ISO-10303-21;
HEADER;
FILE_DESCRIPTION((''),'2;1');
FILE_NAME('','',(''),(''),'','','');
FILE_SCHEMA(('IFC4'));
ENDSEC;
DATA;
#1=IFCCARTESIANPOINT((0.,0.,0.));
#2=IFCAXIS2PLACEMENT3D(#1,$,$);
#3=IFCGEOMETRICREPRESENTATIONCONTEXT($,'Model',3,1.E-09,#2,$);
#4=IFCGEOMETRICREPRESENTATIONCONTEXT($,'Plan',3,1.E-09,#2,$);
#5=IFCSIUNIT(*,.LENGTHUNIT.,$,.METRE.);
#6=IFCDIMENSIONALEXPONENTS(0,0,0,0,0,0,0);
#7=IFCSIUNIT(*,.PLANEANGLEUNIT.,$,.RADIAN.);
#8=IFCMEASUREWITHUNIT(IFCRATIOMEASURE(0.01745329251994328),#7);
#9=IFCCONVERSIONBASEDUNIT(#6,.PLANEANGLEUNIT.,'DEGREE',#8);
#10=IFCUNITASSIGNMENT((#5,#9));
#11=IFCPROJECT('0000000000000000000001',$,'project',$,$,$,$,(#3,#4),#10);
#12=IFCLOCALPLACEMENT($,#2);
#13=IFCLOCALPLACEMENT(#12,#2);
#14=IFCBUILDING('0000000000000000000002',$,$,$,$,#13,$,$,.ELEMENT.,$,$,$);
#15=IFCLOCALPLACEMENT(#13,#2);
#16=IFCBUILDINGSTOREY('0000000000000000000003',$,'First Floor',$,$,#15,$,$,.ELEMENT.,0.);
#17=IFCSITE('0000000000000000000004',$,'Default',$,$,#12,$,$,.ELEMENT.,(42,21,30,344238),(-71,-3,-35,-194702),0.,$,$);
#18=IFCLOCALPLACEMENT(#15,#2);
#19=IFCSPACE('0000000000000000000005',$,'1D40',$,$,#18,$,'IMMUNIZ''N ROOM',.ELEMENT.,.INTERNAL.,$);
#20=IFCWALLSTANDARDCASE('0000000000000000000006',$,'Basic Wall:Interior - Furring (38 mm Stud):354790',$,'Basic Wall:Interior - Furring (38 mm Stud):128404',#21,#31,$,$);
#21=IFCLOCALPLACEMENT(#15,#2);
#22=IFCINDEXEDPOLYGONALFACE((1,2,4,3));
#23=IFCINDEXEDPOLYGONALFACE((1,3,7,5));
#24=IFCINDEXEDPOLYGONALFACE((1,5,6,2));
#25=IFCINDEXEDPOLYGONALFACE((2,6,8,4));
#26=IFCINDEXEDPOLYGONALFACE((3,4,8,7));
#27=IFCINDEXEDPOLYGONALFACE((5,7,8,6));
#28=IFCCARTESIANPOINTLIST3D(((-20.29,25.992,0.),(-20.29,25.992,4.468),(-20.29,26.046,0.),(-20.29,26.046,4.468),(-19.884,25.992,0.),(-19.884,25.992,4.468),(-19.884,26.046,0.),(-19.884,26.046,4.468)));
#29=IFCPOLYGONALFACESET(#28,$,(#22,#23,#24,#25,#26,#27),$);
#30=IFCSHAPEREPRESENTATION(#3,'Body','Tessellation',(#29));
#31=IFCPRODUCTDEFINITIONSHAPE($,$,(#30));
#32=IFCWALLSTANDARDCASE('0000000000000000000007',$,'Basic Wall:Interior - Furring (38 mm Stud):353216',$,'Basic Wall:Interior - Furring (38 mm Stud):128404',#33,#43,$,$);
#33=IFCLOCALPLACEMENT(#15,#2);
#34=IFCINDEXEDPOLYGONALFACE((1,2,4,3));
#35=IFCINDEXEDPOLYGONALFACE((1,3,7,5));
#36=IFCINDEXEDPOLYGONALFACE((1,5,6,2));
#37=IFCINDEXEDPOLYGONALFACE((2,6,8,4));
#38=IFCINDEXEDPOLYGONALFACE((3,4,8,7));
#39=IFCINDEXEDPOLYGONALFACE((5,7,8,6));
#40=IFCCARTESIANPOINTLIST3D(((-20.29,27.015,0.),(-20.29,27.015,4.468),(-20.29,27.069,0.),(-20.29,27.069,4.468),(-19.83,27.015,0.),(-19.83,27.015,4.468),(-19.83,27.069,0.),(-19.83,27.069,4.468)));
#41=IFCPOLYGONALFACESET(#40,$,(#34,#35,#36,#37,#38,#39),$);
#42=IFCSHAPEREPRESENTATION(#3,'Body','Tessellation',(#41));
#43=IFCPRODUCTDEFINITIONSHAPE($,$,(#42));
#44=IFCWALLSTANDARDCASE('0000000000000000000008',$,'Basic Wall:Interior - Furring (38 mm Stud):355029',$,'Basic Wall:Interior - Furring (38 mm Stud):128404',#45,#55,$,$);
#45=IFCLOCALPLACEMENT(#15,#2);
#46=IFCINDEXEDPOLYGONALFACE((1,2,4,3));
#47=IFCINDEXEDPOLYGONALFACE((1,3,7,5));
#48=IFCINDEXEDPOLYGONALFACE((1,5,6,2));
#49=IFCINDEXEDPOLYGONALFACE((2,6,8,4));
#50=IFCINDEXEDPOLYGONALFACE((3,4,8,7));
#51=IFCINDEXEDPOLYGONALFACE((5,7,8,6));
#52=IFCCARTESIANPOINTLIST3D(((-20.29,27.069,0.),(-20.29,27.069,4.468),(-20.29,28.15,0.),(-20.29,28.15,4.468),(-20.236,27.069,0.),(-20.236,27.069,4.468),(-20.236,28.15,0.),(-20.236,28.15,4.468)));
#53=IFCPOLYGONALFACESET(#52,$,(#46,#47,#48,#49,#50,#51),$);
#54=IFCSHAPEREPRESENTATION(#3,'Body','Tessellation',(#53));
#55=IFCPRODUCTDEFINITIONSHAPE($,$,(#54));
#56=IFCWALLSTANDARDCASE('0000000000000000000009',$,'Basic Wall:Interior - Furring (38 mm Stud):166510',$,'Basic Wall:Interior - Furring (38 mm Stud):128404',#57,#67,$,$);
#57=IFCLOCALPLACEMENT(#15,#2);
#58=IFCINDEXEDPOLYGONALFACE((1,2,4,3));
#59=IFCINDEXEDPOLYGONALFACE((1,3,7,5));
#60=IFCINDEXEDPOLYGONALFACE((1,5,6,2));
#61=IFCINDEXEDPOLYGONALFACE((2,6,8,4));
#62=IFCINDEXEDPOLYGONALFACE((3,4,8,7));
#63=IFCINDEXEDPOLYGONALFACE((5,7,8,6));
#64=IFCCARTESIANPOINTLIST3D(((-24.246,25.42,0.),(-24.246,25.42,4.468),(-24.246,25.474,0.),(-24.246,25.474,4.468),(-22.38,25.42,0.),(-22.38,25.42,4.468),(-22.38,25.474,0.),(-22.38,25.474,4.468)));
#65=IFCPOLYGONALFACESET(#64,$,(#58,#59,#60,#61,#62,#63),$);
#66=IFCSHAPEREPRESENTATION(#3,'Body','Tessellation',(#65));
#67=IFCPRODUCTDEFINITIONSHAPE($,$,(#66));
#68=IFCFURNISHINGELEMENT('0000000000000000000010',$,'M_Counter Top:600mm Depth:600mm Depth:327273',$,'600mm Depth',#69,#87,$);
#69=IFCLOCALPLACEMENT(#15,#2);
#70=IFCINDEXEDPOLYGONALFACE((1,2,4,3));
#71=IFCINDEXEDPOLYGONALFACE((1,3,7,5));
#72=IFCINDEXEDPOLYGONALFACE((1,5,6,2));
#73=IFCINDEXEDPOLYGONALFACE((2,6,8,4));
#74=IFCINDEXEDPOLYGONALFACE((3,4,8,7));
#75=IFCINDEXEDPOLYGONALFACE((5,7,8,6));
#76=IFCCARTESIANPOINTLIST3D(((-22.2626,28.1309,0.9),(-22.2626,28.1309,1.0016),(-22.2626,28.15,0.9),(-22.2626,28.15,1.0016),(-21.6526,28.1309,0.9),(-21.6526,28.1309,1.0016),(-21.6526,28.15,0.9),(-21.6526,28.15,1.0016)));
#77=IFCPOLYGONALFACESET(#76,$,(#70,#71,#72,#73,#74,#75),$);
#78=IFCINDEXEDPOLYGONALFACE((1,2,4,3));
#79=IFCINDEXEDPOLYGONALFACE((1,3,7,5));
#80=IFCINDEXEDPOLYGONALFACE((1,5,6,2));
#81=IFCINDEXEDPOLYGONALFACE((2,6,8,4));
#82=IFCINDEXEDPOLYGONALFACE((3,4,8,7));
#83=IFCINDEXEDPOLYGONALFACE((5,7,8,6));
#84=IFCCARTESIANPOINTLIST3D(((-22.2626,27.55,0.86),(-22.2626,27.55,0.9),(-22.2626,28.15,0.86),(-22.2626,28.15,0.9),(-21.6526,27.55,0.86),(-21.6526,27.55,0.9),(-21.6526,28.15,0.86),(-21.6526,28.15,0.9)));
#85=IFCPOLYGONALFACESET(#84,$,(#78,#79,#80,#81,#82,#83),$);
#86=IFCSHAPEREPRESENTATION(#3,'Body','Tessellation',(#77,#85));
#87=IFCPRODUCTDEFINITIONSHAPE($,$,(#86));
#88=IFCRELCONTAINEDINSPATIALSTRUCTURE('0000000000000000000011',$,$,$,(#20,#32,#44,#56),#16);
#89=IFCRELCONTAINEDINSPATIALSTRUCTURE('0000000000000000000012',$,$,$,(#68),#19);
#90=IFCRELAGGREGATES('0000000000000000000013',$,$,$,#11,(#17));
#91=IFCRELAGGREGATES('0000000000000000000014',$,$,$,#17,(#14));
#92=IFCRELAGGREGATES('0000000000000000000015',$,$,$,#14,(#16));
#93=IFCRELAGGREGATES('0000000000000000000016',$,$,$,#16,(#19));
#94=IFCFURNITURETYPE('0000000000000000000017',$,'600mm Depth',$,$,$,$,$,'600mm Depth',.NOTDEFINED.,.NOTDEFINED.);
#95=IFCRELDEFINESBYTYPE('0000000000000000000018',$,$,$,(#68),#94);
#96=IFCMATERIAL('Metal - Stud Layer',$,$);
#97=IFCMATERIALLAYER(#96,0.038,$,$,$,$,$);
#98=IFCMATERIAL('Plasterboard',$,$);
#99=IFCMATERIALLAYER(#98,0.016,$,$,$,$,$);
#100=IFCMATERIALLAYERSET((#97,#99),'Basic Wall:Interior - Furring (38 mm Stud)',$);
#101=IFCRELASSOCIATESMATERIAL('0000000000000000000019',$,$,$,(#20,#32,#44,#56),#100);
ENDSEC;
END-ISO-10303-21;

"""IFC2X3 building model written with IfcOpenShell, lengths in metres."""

from ifc_helpers import new_model, entity, si_unit, converted_unit, frame, frame_2d, origin, origin_2d_with_axis, place, context, project, spatial, rectangle, extrude, source, transform, mapped, material, layer, layer_set, layer_usage, type_object, type_shapes, element, save


model = new_model("IFC2X3")

# Units and contexts
model_context = context("Model", 3, precision=1e-09, world=origin())
plan_context = context("Plan", 3, precision=1e-09, world=origin())
ifc_project = project(units=[si_unit("LENGTHUNIT", "METRE"), converted_unit("PLANEANGLEUNIT", "DEGREE", entity("IfcRatioMeasure", 0.01745329251994328), si_unit("PLANEANGLEUNIT", "RADIAN"), dimensions=[0, 0, 0, 0, 0, 0, 0])], contexts=[model_context, plan_context])

# Site, building, storey
site_placement = place(None, origin())
site = spatial("IfcSite", under=ifc_project, at=site_placement, Name="Default", CompositionType="ELEMENT", RefLatitude=(42, 21, 30, 344238), RefLongitude=(-71, -3, -35, -194702), RefElevation=0.0)
building_placement = place(site_placement, origin())
building = spatial("IfcBuilding", under=site, at=building_placement, CompositionType="ELEMENT")
storey_placement = place(building_placement, origin())
storey = spatial("IfcBuildingStorey", under=building, at=storey_placement, Name="First Floor", CompositionType="ELEMENT", Elevation=0.0)

# Shared definitions
ifc_material_1 = material(Name="Metal - Stud Layer")
ifc_material_2 = material(Name="Plasterboard")

# Shared definitions
ifc_layer_1 = layer(ifc_material_1, 0.038)
ifc_layer_2 = layer(ifc_material_2, 0.016)
ifc_layer_set_1 = layer_set([ifc_layer_1, ifc_layer_2], Name="Basic Wall:Interior - Furring (38 mm Stud)")
ifc_layer_usage_1 = layer_usage(ifc_layer_set_1, "AXIS2", "POSITIVE", -0.027)
ifc_layer_usage_2 = layer_usage(ifc_layer_set_1, "AXIS2", "NEGATIVE", 0.027)

# Walls
wall_1_placement = place(storey_placement, frame((-19.884, 26.019, 0.0), z_axis=(0.0, 0.0, 1.0), x_axis=(-1.0, 0.0, 0.0)))
element("IfcWallStandardCase", 1, at=wall_1_placement, inside=storey, material=ifc_layer_usage_2, Name="Basic Wall:Interior - Furring (38 mm Stud):354790", ObjectType="Basic Wall:Interior - Furring (38 mm Stud):128404", context=model_context, shape_type="SweptSolid", body=[
    extrude(rectangle(XDim=0.406, YDim=0.054, at=frame_2d((0.203, 0.0), x_axis=(-1.0, 0.0))), origin(), (0.0, 0.0, 1.0), 4.468),
])
wall_2_placement = place(storey_placement, frame((-20.29, 27.042, 0.0)))
element("IfcWallStandardCase", 2, at=wall_2_placement, inside=storey, material=ifc_layer_usage_2, Name="Basic Wall:Interior - Furring (38 mm Stud):353216", ObjectType="Basic Wall:Interior - Furring (38 mm Stud):128404", context=model_context, shape_type="SweptSolid", body=[
    extrude(rectangle(XDim=0.46, YDim=0.054, at=frame_2d((0.23, 0.0), x_axis=(-1.0, 0.0))), origin(), (0.0, 0.0, 1.0), 4.468),
])
wall_3_placement = place(storey_placement, frame((-20.263, 28.15, 0.0), z_axis=(0.0, 0.0, 1.0), x_axis=(0.0, -1.0, 0.0)))
element("IfcWallStandardCase", 3, at=wall_3_placement, inside=storey, material=ifc_layer_usage_2, Name="Basic Wall:Interior - Furring (38 mm Stud):355029", ObjectType="Basic Wall:Interior - Furring (38 mm Stud):128404", context=model_context, shape_type="SweptSolid", body=[
    extrude(rectangle(XDim=1.081, YDim=0.054, at=frame_2d((0.5405, 0.0), x_axis=(-1.0, 0.0))), origin(), (0.0, 0.0, 1.0), 4.468),
])
wall_4_placement = place(storey_placement, frame((-22.38, 25.447, 0.0), z_axis=(0.0, 0.0, 1.0), x_axis=(-1.0, 0.0, 0.0)))
element("IfcWallStandardCase", 4, at=wall_4_placement, inside=storey, material=ifc_layer_usage_1, Name="Basic Wall:Interior - Furring (38 mm Stud):166510", ObjectType="Basic Wall:Interior - Furring (38 mm Stud):128404", context=model_context, shape_type="SweptSolid", body=[
    extrude(rectangle(XDim=1.866, YDim=0.054, at=frame_2d((0.933, 0.0), x_axis=(-1.0, 0.0))), origin(), (0.0, 0.0, 1.0), 4.468),
])

# Shared definitions
space_placement = place(storey_placement, origin())
space = spatial("IfcSpace", under=storey, at=space_placement, Name="1D40", LongName="IMMUNIZ'N ROOM", CompositionType="ELEMENT", InteriorOrExteriorSpace="INTERNAL")

# Furnishing element
furniture_type = type_object("IfcFurnitureType", Name="600mm Depth", ElementType="600mm Depth", AssemblyPlace="NOTDEFINED")
shared_shape_1 = source(origin(), model_context, "Body", "SweptSolid", [
    extrude(rectangle(XDim=0.0191, YDim=0.61, at=origin_2d_with_axis()), frame((-0.8955, -0.0095, 0.9), z_axis=(0.0, 0.0, 1.0), x_axis=(0.0, -1.0, 0.0)), (0.0, 0.0, 1.0), 0.1016),
    extrude(rectangle(XDim=0.61, YDim=0.6, at=origin_2d_with_axis()), frame((-0.8955, -0.3, 0.86), z_axis=(0.0, 0.0, 1.0), x_axis=(-1.0, 0.0, 0.0)), (0.0, 0.0, 1.0), 0.04),
])
type_shapes(furniture_type, [shared_shape_1])
furnishing_placement = place(space_placement, frame((-21.0621, 28.15, 0.0)))
element("IfcFurnishingElement", 5, at=furnishing_placement, inside=space, type_object=furniture_type, Name="M_Counter Top:600mm Depth:600mm Depth:327273", ObjectType="600mm Depth", context=model_context, shape_type="MappedRepresentation", body=[
    mapped(shared_shape_1, transform((0.0, 0.0, 0.0), scale=1.0)),
])

save(model, "model.ifc")
